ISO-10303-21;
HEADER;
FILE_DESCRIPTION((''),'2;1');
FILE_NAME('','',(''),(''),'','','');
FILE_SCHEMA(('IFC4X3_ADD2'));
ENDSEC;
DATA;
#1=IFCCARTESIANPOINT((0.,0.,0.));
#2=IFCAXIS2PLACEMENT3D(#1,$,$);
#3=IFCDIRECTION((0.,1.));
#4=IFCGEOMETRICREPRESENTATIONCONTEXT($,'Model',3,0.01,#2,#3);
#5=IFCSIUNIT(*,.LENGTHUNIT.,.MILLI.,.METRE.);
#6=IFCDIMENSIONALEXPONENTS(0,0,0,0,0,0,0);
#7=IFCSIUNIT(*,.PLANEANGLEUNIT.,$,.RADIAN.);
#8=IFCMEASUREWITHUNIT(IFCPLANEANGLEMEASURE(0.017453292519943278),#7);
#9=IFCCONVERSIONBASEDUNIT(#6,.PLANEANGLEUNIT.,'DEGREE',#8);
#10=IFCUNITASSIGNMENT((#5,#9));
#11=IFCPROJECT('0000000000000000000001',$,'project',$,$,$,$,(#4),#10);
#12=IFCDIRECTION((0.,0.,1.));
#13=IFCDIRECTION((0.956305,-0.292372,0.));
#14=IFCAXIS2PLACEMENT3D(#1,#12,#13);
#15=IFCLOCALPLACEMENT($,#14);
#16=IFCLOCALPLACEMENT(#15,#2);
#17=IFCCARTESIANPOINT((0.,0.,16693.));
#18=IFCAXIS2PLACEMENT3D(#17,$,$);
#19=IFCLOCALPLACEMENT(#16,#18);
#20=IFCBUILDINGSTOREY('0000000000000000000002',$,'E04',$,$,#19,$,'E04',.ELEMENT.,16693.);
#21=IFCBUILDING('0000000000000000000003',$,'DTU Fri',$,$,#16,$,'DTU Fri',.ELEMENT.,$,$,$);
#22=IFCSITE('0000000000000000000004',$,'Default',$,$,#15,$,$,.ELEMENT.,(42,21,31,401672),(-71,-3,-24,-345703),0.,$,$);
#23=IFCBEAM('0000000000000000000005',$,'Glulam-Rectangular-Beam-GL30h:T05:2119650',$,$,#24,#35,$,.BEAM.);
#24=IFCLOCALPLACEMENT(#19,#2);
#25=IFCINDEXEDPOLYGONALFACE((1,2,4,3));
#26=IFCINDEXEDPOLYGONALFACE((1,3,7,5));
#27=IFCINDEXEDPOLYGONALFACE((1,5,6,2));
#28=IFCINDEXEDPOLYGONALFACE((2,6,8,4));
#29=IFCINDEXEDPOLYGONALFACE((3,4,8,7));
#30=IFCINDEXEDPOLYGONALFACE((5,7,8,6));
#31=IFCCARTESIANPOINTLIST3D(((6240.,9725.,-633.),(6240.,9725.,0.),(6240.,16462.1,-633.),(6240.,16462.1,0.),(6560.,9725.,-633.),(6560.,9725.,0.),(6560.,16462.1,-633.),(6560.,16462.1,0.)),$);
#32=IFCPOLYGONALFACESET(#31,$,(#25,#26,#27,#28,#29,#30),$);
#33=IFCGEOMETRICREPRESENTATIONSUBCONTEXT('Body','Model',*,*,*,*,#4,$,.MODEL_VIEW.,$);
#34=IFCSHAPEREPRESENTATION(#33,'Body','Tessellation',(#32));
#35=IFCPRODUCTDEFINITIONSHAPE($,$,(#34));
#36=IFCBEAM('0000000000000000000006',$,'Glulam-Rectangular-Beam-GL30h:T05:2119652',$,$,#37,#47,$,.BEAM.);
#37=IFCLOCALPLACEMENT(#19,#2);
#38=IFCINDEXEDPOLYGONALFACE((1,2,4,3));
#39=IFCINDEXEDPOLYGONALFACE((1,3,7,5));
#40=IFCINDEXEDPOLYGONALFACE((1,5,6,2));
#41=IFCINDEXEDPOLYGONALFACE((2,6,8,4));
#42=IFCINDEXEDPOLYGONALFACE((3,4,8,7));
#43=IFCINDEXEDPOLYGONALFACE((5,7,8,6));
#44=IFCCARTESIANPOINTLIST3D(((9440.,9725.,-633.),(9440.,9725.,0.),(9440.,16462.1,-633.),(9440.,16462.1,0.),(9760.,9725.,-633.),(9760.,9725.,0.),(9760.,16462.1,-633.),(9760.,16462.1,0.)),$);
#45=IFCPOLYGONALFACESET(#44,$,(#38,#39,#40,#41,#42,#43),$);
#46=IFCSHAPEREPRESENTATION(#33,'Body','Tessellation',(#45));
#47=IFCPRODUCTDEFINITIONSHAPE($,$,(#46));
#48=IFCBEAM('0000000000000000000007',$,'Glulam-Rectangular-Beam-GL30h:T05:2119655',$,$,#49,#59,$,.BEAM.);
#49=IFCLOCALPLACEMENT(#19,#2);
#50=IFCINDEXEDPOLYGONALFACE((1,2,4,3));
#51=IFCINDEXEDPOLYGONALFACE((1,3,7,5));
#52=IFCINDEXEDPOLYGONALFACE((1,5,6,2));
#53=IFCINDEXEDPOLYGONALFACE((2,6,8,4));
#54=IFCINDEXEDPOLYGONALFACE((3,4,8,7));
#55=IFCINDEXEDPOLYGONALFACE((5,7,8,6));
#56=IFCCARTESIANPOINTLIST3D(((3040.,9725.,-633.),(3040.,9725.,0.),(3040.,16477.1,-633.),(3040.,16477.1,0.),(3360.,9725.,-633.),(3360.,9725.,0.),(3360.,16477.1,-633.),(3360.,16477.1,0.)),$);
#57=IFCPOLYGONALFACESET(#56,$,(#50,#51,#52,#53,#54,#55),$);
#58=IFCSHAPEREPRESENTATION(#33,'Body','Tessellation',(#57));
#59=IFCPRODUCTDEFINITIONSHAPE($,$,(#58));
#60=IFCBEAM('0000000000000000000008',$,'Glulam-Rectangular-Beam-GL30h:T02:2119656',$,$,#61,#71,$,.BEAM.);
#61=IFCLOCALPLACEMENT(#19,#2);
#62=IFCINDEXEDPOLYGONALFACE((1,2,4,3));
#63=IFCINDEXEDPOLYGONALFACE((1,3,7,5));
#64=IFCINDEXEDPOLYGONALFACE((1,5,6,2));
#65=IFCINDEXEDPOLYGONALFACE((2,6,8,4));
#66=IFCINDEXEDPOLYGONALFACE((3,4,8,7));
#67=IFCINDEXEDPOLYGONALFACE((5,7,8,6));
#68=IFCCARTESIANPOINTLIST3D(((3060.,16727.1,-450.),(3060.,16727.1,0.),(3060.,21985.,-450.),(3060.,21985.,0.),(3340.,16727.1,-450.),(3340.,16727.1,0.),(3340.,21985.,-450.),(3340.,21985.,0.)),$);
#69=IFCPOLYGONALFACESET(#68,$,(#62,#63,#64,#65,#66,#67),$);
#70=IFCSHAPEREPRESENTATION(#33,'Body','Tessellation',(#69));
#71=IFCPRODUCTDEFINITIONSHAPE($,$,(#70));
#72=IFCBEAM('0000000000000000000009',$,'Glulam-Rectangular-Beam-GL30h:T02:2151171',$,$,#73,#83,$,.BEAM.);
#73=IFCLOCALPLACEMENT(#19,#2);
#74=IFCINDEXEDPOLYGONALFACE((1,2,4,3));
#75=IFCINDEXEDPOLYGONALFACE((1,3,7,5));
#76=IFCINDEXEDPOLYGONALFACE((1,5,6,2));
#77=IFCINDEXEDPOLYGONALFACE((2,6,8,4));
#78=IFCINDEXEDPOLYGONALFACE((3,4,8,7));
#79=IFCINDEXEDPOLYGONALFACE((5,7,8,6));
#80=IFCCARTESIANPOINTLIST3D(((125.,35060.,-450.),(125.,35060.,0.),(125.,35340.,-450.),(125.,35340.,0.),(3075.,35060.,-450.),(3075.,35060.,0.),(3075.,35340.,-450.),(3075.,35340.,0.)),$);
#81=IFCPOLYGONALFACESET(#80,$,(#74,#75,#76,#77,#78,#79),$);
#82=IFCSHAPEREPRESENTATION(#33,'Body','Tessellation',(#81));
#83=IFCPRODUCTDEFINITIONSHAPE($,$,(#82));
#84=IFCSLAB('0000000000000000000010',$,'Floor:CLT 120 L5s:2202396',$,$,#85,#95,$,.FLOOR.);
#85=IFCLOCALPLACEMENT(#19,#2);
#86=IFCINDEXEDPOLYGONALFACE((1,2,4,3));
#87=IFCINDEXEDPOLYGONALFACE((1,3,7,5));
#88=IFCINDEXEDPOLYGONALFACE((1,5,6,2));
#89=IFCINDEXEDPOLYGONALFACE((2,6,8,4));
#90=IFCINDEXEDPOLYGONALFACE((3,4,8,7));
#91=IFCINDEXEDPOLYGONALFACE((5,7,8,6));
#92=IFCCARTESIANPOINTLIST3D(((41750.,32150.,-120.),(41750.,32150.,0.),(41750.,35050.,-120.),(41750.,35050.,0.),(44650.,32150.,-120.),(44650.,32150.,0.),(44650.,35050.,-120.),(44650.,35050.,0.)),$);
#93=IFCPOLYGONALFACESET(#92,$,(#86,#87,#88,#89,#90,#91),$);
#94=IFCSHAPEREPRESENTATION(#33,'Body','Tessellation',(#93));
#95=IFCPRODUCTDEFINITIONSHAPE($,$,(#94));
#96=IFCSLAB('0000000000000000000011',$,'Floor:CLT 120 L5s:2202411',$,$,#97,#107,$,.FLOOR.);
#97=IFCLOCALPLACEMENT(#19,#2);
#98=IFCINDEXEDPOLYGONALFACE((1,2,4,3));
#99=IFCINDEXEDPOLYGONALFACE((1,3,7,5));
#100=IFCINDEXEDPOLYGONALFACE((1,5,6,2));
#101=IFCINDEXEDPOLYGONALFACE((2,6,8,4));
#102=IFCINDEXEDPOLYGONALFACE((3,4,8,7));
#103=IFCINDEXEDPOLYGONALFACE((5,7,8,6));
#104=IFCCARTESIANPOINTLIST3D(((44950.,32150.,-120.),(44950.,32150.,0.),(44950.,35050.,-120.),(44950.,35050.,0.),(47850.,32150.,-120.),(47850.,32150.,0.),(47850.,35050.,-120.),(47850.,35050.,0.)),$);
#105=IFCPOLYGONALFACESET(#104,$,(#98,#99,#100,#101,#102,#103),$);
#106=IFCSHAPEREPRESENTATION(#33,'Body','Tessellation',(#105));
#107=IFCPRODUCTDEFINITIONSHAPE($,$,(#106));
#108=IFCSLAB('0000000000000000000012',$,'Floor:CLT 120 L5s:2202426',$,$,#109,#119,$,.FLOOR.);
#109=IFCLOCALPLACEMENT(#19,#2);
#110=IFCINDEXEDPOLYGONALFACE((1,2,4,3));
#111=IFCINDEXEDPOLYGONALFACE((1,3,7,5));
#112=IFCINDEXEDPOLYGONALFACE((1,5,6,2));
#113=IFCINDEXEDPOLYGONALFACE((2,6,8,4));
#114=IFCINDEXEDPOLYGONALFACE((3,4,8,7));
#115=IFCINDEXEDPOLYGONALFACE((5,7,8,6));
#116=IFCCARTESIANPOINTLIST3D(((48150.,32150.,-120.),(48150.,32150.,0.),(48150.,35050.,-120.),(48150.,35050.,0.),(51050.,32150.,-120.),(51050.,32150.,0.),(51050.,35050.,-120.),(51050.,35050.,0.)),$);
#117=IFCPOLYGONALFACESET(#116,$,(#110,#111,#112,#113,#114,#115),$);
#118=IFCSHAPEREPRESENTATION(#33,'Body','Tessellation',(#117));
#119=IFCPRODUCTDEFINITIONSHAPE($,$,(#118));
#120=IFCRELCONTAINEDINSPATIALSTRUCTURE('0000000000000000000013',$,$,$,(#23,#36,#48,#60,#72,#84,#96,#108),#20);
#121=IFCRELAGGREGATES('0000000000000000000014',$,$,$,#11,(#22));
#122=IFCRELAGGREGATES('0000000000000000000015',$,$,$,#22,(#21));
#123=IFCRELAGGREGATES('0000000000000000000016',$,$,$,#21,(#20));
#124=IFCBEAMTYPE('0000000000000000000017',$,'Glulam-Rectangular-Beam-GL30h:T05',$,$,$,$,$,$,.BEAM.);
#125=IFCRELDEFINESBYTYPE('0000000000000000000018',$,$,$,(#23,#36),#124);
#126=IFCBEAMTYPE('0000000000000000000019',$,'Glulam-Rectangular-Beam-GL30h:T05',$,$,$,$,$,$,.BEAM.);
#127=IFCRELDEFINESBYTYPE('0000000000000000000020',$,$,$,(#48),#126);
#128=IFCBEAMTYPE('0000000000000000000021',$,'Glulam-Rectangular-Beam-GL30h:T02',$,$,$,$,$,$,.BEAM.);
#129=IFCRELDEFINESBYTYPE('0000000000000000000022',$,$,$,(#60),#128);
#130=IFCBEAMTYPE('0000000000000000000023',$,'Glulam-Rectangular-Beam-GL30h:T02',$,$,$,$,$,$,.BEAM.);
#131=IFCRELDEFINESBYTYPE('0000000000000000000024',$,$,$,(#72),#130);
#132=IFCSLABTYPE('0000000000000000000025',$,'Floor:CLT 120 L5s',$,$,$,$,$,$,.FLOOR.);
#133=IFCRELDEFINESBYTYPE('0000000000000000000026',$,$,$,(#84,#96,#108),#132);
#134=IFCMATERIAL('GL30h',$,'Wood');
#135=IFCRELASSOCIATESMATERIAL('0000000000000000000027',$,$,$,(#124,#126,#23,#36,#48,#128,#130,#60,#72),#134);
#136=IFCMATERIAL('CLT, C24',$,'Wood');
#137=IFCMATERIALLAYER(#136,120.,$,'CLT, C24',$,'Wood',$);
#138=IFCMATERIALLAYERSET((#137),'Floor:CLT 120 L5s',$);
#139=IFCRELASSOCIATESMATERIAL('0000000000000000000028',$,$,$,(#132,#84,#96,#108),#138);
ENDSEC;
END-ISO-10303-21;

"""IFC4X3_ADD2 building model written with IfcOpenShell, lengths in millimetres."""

from ifc_helpers import new_model, entity, si_unit, converted_unit, direction, frame, frame_2d, origin, origin_2d_with_axis, place, context, subcontext, project, spatial, rectangle, extrude, source, transform, mapped, material, layer, layer_set, layer_usage, material_profile, profile_set, profile_usage, type_object, type_shapes, element, save


model = new_model("IFC4X3_ADD2")

# Units and contexts
model_context = context("Model", 3, precision=0.01, world=origin(), true_north=direction((0.0, 1.0)))
body_context = subcontext(model_context, "Body", "Model", "MODEL_VIEW")
ifc_project = project(units=[si_unit("LENGTHUNIT", "METRE", prefix="MILLI"), converted_unit("PLANEANGLEUNIT", "DEGREE", entity("IfcPlaneAngleMeasure", 0.017453292519943278), si_unit("PLANEANGLEUNIT", "RADIAN"), dimensions=[0, 0, 0, 0, 0, 0, 0])], contexts=[model_context])

# Site, building, storey
site_placement = place(None, frame((0.0, 0.0, 0.0), z_axis=(0.0, 0.0, 1.0), x_axis=(0.956305, -0.292372, 0.0)))
site = spatial("IfcSite", under=ifc_project, at=site_placement, Name="Default", CompositionType="ELEMENT", RefLatitude=(42, 21, 31, 401672), RefLongitude=(-71, -3, -24, -345703), RefElevation=0.0)
building_placement = place(site_placement, origin())
building = spatial("IfcBuilding", under=site, at=building_placement, Name="DTU Fri", LongName="DTU Fri", CompositionType="ELEMENT")
storey_placement = place(building_placement, frame((0.0, 0.0, 16693.0)))
storey = spatial("IfcBuildingStorey", under=building, at=storey_placement, Name="E04", LongName="E04", CompositionType="ELEMENT", Elevation=16693.0)

# Beams
ifc_material_1 = material(Name="GL30h", Category="Wood")
ifc_material_profile_1 = material_profile(ifc_material_1, rectangle(XDim=633.0, YDim=320.0, at=origin_2d_with_axis()), Name="T05")
ifc_profile_set_1 = profile_set([ifc_material_profile_1], Name="T05")
ifc_profile_usage_1 = profile_usage(ifc_profile_set_1, cardinal=8)
ifc_material_profile_2 = material_profile(ifc_material_1, rectangle(XDim=450.0, YDim=280.0, at=origin_2d_with_axis()), Name="T02")
ifc_profile_set_2 = profile_set([ifc_material_profile_2], Name="T02")
ifc_profile_usage_2 = profile_usage(ifc_profile_set_2, cardinal=8)
beam_type_1 = type_object("IfcBeamType", Name="Glulam-Rectangular-Beam-GL30h:T05", PredefinedType="BEAM", material=ifc_profile_set_1)
shared_shape_1 = source(origin(), body_context, "Body", "SweptSolid", [
    extrude(rectangle(XDim=633.0, YDim=320.0, at=origin_2d_with_axis()), frame((-3376.0, 0.0, 0.0), z_axis=(1.0, 0.0, 0.0), x_axis=(0.0, 0.0, -1.0)), (0.0, 0.0, 1.0), 6737.1),
])
type_shapes(beam_type_1, [shared_shape_1])
for number, where, z_axis, x_axis, name in (
    (1, (6400.0, 13101.0, -316.5), (0.0, 0.0, 1.0), (0.0, 1.0, 0.0), "Glulam-Rectangular-Beam-GL30h:T05:2119650"),
    (2, (9600.0, 13101.0, -316.5), (0.0, 0.0, 1.0), (0.0, 1.0, 0.0), "Glulam-Rectangular-Beam-GL30h:T05:2119652"),
):
    element("IfcBeam", number, at=place(storey_placement, frame(where, z_axis=z_axis, x_axis=x_axis)), inside=storey, type_object=beam_type_1, material=ifc_profile_usage_1, Name=name, PredefinedType="BEAM", context=body_context, shape_type="MappedRepresentation", body=[
        mapped(shared_shape_1, transform((0.0, 0.0, 0.0), scale=1.0)),
    ])
beam_type_2 = type_object("IfcBeamType", Name="Glulam-Rectangular-Beam-GL30h:T05", PredefinedType="BEAM", material=ifc_profile_set_1)
shared_shape_2 = source(origin(), body_context, "Body", "SweptSolid", [
    extrude(rectangle(XDim=633.0, YDim=320.0, at=origin_2d_with_axis()), frame((-3376.0, 0.0, 0.0), z_axis=(1.0, 0.0, 0.0), x_axis=(0.0, 0.0, -1.0)), (0.0, 0.0, 1.0), 6752.1),
])
type_shapes(beam_type_2, [shared_shape_2])
beam_1_placement = place(storey_placement, frame((3200.0, 13101.0, -316.5), z_axis=(0.0, 0.0, 1.0), x_axis=(0.0, 1.0, 0.0)))
element("IfcBeam", 3, at=beam_1_placement, inside=storey, type_object=beam_type_2, material=ifc_profile_usage_1, Name="Glulam-Rectangular-Beam-GL30h:T05:2119655", PredefinedType="BEAM", context=body_context, shape_type="MappedRepresentation", body=[
    mapped(shared_shape_2, transform((0.0, 0.0, 0.0), scale=1.0)),
])
beam_type_3 = type_object("IfcBeamType", Name="Glulam-Rectangular-Beam-GL30h:T02", PredefinedType="BEAM", material=ifc_profile_set_2)
shared_shape_3 = source(origin(), body_context, "Body", "SweptSolid", [
    extrude(rectangle(XDim=450.0, YDim=280.0, at=origin_2d_with_axis()), frame((-2629.0, 0.0, 0.0), z_axis=(1.0, 0.0, 0.0), x_axis=(0.0, 0.0, -1.0)), (0.0, 0.0, 1.0), 5257.9),
])
type_shapes(beam_type_3, [shared_shape_3])
beam_2_placement = place(storey_placement, frame((3200.0, 19356.0, -225.0), z_axis=(0.0, 0.0, 1.0), x_axis=(0.0, 1.0, 0.0)))
element("IfcBeam", 4, at=beam_2_placement, inside=storey, type_object=beam_type_3, material=ifc_profile_usage_2, Name="Glulam-Rectangular-Beam-GL30h:T02:2119656", PredefinedType="BEAM", context=body_context, shape_type="MappedRepresentation", body=[
    mapped(shared_shape_3, transform((0.0, 0.0, 0.0), scale=1.0)),
])
beam_type_4 = type_object("IfcBeamType", Name="Glulam-Rectangular-Beam-GL30h:T02", PredefinedType="BEAM", material=ifc_profile_set_2)
shared_shape_4 = source(origin(), body_context, "Body", "SweptSolid", [
    extrude(rectangle(XDim=450.0, YDim=280.0, at=origin_2d_with_axis()), frame((-1475.0, 0.0, 0.0), z_axis=(1.0, 0.0, 0.0), x_axis=(0.0, 0.0, -1.0)), (0.0, 0.0, 1.0), 2950.0),
])
type_shapes(beam_type_4, [shared_shape_4])
beam_3_placement = place(storey_placement, frame((1600.0, 35200.0, -225.0), z_axis=(0.0, 0.0, 1.0), x_axis=(-1.0, 0.0, 0.0)))
element("IfcBeam", 5, at=beam_3_placement, inside=storey, type_object=beam_type_4, material=ifc_profile_usage_2, Name="Glulam-Rectangular-Beam-GL30h:T02:2151171", PredefinedType="BEAM", context=body_context, shape_type="MappedRepresentation", body=[
    mapped(shared_shape_4, transform((0.0, 0.0, 0.0), scale=1.0)),
])

# Slabs
ifc_material_2 = material(Name="CLT, C24", Category="Wood")
ifc_layer = layer(ifc_material_2, 120.0, Name="CLT, C24", Category="Wood")
ifc_layer_set = layer_set([ifc_layer], Name="Floor:CLT 120 L5s")
ifc_layer_usage_1 = layer_usage(ifc_layer_set, "AXIS3", "POSITIVE", 0.0)
slab_type = type_object("IfcSlabType", Name="Floor:CLT 120 L5s", PredefinedType="FLOOR", material=ifc_layer_set)
slab_1_placement = place(storey_placement, origin())
element("IfcSlab", 6, at=slab_1_placement, inside=storey, type_object=slab_type, material=ifc_layer_usage_1, Name="Floor:CLT 120 L5s:2202396", PredefinedType="FLOOR", context=body_context, shape_type="SweptSolid", body=[
    extrude(rectangle(XDim=2900.0, YDim=2900.0, at=frame_2d((0.0, 0.0), x_axis=(1.0, 0.0))), frame((43200.0, 33600.0, 0.0), z_axis=(0.0, 0.0, -1.0), x_axis=(0.0, 1.0, 0.0)), (0.0, 0.0, 1.0), 120.0),
])
ifc_layer_usage_2 = layer_usage(ifc_layer_set, "AXIS3", "POSITIVE", 0.0)
slab_2_placement = place(storey_placement, origin())
element("IfcSlab", 7, at=slab_2_placement, inside=storey, type_object=slab_type, material=ifc_layer_usage_2, Name="Floor:CLT 120 L5s:2202411", PredefinedType="FLOOR", context=body_context, shape_type="SweptSolid", body=[
    extrude(rectangle(XDim=2900.0, YDim=2900.0, at=origin_2d_with_axis()), frame((46400.0, 33600.0, 0.0), z_axis=(0.0, 0.0, -1.0), x_axis=(0.0, 1.0, 0.0)), (0.0, 0.0, 1.0), 120.0),
])
ifc_layer_usage_3 = layer_usage(ifc_layer_set, "AXIS3", "POSITIVE", 0.0)
slab_3_placement = place(storey_placement, origin())
element("IfcSlab", 8, at=slab_3_placement, inside=storey, type_object=slab_type, material=ifc_layer_usage_3, Name="Floor:CLT 120 L5s:2202426", PredefinedType="FLOOR", context=body_context, shape_type="SweptSolid", body=[
    extrude(rectangle(XDim=2900.0, YDim=2900.0, at=frame_2d((0.0, 0.0), x_axis=(1.0, 0.0))), frame((49600.0, 33600.0, 0.0), z_axis=(0.0, 0.0, -1.0), x_axis=(0.0, 1.0, 0.0)), (0.0, 0.0, 1.0), 120.0),
])

save(model, "model.ifc")
